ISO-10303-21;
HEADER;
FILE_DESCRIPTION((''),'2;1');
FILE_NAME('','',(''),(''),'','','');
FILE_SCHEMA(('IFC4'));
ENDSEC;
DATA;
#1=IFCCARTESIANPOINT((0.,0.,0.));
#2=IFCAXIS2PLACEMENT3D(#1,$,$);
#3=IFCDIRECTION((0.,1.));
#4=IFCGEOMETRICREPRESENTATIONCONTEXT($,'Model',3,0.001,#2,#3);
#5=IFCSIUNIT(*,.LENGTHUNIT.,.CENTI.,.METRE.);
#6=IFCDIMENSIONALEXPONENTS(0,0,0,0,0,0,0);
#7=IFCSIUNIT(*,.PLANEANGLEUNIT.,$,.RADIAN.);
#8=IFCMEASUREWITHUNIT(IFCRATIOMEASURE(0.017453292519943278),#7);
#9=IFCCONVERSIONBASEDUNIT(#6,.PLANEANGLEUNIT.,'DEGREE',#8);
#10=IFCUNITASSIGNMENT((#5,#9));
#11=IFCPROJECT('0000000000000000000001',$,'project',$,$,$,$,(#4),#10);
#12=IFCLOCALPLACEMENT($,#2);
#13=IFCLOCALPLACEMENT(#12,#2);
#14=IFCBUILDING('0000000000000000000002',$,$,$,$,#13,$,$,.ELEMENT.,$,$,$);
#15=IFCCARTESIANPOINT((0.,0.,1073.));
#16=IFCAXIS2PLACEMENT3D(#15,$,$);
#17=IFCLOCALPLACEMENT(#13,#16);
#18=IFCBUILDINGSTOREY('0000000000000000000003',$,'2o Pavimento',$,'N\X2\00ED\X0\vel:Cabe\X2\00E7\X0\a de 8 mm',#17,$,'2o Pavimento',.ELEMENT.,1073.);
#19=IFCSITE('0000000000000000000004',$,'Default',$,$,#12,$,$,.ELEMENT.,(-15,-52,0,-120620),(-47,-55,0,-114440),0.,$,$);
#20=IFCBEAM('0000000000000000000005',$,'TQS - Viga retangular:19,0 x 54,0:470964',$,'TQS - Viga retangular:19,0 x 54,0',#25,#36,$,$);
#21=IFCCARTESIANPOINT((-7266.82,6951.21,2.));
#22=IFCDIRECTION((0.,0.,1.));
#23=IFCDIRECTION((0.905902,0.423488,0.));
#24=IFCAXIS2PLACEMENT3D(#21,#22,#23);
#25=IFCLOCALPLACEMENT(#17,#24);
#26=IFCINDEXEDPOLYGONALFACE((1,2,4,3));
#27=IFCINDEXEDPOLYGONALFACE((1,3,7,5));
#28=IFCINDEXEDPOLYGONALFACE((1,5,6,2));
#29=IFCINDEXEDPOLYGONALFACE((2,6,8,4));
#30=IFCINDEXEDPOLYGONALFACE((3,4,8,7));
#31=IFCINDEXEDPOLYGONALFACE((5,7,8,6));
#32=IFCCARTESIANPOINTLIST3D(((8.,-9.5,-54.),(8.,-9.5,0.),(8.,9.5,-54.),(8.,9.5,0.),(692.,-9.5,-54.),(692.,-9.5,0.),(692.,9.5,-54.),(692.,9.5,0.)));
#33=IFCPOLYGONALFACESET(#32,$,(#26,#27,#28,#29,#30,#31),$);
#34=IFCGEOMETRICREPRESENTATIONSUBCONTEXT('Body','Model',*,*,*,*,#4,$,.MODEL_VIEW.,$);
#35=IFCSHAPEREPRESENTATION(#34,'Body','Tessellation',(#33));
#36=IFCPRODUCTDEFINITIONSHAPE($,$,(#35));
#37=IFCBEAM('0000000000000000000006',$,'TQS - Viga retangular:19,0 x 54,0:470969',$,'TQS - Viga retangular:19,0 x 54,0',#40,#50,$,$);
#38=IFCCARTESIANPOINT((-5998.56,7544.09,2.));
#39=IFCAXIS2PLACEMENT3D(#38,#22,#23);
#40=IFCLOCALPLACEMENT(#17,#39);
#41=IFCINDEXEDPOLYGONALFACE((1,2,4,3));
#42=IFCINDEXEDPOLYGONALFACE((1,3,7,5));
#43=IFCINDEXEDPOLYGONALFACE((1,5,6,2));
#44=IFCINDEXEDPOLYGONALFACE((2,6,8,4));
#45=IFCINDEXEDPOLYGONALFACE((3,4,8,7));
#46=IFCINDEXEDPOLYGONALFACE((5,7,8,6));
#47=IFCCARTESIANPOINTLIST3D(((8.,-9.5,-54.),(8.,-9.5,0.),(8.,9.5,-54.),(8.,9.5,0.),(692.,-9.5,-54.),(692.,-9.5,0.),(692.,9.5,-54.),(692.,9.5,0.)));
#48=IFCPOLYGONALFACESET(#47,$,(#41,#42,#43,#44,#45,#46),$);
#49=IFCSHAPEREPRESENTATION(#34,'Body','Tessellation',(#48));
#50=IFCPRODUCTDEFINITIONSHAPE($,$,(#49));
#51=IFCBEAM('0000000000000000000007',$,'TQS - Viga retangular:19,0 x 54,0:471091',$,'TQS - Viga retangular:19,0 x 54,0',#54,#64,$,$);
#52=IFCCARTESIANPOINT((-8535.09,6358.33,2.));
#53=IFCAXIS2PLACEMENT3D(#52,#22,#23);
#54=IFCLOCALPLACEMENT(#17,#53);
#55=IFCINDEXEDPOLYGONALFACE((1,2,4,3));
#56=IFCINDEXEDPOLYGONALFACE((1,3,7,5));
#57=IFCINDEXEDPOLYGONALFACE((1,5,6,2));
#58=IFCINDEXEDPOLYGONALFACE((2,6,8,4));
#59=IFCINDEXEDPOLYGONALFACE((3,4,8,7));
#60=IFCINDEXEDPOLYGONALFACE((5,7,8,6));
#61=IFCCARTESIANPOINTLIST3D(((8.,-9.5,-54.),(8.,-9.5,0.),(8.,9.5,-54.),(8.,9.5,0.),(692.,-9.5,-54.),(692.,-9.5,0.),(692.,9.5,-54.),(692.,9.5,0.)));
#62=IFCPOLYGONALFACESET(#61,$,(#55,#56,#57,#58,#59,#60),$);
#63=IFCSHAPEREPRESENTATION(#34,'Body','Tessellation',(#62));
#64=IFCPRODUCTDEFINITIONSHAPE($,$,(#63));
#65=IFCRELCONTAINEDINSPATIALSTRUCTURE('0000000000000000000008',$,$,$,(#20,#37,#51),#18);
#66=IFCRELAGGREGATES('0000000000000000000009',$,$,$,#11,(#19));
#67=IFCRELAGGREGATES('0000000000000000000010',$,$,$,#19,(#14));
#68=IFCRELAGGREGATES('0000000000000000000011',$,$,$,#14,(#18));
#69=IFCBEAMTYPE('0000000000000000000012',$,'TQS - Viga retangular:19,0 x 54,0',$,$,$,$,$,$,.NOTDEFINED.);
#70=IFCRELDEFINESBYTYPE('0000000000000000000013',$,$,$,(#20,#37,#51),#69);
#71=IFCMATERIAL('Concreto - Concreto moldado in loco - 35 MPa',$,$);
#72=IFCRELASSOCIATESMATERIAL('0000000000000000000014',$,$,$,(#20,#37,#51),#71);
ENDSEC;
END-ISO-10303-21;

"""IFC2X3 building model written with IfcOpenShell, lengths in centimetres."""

from ifc_helpers import new_model, entity, si_unit, converted_unit, direction, frame, frame_2d, origin, place, context, subcontext, project, spatial, rectangle, extrude, material, type_object, element, save


model = new_model("IFC2X3")

# Units and contexts
model_context = context("Model", 3, precision=0.001, world=origin(), true_north=direction((0.0, 1.0)))
body_context = subcontext(model_context, "Body", "Model", "MODEL_VIEW")
ifc_project = project(units=[si_unit("LENGTHUNIT", "METRE", prefix="CENTI"), converted_unit("PLANEANGLEUNIT", "DEGREE", entity("IfcRatioMeasure", 0.017453292519943278), si_unit("PLANEANGLEUNIT", "RADIAN"), dimensions=[0, 0, 0, 0, 0, 0, 0])], contexts=[model_context])

# Site, building, storey
site_placement = place(None, origin())
site = spatial("IfcSite", under=ifc_project, at=site_placement, Name="Default", CompositionType="ELEMENT", RefLatitude=(-15, -52, 0, -120620), RefLongitude=(-47, -55, 0, -114440), RefElevation=0.0)
building_placement = place(site_placement, origin())
building = spatial("IfcBuilding", under=site, at=building_placement, CompositionType="ELEMENT")
storey_placement = place(building_placement, frame((0.0, 0.0, 1073.0)))
storey = spatial("IfcBuildingStorey", under=building, at=storey_placement, Name="2o Pavimento", ObjectType="Nível:Cabeça de 8 mm", LongName="2o Pavimento", CompositionType="ELEMENT", Elevation=1073.0)

# Beams
ifc_material_1 = material(Name="Concreto - Concreto moldado in loco - 35 MPa")
beam_type_1 = type_object("IfcBeamType", Name="TQS - Viga retangular:19,0 x 54,0", PredefinedType="NOTDEFINED")
beam_1_placement = place(storey_placement, frame((-7266.82, 6951.21, 2.0), z_axis=(0.0, 0.0, 1.0), x_axis=(0.905902, 0.423488, 0.0)))
element("IfcBeam", 1, at=beam_1_placement, inside=storey, type_object=beam_type_1, material=ifc_material_1, Name="TQS - Viga retangular:19,0 x 54,0:470964", ObjectType="TQS - Viga retangular:19,0 x 54,0", context=body_context, shape_type="SweptSolid", body=[
    extrude(rectangle(XDim=54.0, YDim=19.0, at=frame_2d((0.0, 0.0), x_axis=(1.0, 0.0))), frame((8.0, 0.0, -27.0), z_axis=(1.0, 0.0, 0.0), x_axis=(0.0, 0.0, -1.0)), (0.0, 0.0, 1.0), 684.0),
])
beam_2_placement = place(storey_placement, frame((-5998.56, 7544.09, 2.0), z_axis=(0.0, 0.0, 1.0), x_axis=(0.905902, 0.423488, 0.0)))
element("IfcBeam", 2, at=beam_2_placement, inside=storey, type_object=beam_type_1, material=ifc_material_1, Name="TQS - Viga retangular:19,0 x 54,0:470969", ObjectType="TQS - Viga retangular:19,0 x 54,0", context=body_context, shape_type="SweptSolid", body=[
    extrude(rectangle(XDim=54.0, YDim=19.0, at=frame_2d((0.0, 0.0), x_axis=(1.0, 0.0))), frame((8.0, 0.0, -27.0), z_axis=(1.0, 0.0, 0.0), x_axis=(0.0, 0.0, -1.0)), (0.0, 0.0, 1.0), 684.0),
])
beam_3_placement = place(storey_placement, frame((-8535.09, 6358.33, 2.0), z_axis=(0.0, 0.0, 1.0), x_axis=(0.905902, 0.423488, 0.0)))
element("IfcBeam", 3, at=beam_3_placement, inside=storey, type_object=beam_type_1, material=ifc_material_1, Name="TQS - Viga retangular:19,0 x 54,0:471091", ObjectType="TQS - Viga retangular:19,0 x 54,0", context=body_context, shape_type="SweptSolid", body=[
    extrude(rectangle(XDim=54.0, YDim=19.0, at=frame_2d((0.0, 0.0), x_axis=(1.0, 0.0))), frame((8.0, 0.0, -27.0), z_axis=(1.0, 0.0, 0.0), x_axis=(0.0, 0.0, -1.0)), (0.0, 0.0, 1.0), 684.0),
])

save(model, "model.ifc")
